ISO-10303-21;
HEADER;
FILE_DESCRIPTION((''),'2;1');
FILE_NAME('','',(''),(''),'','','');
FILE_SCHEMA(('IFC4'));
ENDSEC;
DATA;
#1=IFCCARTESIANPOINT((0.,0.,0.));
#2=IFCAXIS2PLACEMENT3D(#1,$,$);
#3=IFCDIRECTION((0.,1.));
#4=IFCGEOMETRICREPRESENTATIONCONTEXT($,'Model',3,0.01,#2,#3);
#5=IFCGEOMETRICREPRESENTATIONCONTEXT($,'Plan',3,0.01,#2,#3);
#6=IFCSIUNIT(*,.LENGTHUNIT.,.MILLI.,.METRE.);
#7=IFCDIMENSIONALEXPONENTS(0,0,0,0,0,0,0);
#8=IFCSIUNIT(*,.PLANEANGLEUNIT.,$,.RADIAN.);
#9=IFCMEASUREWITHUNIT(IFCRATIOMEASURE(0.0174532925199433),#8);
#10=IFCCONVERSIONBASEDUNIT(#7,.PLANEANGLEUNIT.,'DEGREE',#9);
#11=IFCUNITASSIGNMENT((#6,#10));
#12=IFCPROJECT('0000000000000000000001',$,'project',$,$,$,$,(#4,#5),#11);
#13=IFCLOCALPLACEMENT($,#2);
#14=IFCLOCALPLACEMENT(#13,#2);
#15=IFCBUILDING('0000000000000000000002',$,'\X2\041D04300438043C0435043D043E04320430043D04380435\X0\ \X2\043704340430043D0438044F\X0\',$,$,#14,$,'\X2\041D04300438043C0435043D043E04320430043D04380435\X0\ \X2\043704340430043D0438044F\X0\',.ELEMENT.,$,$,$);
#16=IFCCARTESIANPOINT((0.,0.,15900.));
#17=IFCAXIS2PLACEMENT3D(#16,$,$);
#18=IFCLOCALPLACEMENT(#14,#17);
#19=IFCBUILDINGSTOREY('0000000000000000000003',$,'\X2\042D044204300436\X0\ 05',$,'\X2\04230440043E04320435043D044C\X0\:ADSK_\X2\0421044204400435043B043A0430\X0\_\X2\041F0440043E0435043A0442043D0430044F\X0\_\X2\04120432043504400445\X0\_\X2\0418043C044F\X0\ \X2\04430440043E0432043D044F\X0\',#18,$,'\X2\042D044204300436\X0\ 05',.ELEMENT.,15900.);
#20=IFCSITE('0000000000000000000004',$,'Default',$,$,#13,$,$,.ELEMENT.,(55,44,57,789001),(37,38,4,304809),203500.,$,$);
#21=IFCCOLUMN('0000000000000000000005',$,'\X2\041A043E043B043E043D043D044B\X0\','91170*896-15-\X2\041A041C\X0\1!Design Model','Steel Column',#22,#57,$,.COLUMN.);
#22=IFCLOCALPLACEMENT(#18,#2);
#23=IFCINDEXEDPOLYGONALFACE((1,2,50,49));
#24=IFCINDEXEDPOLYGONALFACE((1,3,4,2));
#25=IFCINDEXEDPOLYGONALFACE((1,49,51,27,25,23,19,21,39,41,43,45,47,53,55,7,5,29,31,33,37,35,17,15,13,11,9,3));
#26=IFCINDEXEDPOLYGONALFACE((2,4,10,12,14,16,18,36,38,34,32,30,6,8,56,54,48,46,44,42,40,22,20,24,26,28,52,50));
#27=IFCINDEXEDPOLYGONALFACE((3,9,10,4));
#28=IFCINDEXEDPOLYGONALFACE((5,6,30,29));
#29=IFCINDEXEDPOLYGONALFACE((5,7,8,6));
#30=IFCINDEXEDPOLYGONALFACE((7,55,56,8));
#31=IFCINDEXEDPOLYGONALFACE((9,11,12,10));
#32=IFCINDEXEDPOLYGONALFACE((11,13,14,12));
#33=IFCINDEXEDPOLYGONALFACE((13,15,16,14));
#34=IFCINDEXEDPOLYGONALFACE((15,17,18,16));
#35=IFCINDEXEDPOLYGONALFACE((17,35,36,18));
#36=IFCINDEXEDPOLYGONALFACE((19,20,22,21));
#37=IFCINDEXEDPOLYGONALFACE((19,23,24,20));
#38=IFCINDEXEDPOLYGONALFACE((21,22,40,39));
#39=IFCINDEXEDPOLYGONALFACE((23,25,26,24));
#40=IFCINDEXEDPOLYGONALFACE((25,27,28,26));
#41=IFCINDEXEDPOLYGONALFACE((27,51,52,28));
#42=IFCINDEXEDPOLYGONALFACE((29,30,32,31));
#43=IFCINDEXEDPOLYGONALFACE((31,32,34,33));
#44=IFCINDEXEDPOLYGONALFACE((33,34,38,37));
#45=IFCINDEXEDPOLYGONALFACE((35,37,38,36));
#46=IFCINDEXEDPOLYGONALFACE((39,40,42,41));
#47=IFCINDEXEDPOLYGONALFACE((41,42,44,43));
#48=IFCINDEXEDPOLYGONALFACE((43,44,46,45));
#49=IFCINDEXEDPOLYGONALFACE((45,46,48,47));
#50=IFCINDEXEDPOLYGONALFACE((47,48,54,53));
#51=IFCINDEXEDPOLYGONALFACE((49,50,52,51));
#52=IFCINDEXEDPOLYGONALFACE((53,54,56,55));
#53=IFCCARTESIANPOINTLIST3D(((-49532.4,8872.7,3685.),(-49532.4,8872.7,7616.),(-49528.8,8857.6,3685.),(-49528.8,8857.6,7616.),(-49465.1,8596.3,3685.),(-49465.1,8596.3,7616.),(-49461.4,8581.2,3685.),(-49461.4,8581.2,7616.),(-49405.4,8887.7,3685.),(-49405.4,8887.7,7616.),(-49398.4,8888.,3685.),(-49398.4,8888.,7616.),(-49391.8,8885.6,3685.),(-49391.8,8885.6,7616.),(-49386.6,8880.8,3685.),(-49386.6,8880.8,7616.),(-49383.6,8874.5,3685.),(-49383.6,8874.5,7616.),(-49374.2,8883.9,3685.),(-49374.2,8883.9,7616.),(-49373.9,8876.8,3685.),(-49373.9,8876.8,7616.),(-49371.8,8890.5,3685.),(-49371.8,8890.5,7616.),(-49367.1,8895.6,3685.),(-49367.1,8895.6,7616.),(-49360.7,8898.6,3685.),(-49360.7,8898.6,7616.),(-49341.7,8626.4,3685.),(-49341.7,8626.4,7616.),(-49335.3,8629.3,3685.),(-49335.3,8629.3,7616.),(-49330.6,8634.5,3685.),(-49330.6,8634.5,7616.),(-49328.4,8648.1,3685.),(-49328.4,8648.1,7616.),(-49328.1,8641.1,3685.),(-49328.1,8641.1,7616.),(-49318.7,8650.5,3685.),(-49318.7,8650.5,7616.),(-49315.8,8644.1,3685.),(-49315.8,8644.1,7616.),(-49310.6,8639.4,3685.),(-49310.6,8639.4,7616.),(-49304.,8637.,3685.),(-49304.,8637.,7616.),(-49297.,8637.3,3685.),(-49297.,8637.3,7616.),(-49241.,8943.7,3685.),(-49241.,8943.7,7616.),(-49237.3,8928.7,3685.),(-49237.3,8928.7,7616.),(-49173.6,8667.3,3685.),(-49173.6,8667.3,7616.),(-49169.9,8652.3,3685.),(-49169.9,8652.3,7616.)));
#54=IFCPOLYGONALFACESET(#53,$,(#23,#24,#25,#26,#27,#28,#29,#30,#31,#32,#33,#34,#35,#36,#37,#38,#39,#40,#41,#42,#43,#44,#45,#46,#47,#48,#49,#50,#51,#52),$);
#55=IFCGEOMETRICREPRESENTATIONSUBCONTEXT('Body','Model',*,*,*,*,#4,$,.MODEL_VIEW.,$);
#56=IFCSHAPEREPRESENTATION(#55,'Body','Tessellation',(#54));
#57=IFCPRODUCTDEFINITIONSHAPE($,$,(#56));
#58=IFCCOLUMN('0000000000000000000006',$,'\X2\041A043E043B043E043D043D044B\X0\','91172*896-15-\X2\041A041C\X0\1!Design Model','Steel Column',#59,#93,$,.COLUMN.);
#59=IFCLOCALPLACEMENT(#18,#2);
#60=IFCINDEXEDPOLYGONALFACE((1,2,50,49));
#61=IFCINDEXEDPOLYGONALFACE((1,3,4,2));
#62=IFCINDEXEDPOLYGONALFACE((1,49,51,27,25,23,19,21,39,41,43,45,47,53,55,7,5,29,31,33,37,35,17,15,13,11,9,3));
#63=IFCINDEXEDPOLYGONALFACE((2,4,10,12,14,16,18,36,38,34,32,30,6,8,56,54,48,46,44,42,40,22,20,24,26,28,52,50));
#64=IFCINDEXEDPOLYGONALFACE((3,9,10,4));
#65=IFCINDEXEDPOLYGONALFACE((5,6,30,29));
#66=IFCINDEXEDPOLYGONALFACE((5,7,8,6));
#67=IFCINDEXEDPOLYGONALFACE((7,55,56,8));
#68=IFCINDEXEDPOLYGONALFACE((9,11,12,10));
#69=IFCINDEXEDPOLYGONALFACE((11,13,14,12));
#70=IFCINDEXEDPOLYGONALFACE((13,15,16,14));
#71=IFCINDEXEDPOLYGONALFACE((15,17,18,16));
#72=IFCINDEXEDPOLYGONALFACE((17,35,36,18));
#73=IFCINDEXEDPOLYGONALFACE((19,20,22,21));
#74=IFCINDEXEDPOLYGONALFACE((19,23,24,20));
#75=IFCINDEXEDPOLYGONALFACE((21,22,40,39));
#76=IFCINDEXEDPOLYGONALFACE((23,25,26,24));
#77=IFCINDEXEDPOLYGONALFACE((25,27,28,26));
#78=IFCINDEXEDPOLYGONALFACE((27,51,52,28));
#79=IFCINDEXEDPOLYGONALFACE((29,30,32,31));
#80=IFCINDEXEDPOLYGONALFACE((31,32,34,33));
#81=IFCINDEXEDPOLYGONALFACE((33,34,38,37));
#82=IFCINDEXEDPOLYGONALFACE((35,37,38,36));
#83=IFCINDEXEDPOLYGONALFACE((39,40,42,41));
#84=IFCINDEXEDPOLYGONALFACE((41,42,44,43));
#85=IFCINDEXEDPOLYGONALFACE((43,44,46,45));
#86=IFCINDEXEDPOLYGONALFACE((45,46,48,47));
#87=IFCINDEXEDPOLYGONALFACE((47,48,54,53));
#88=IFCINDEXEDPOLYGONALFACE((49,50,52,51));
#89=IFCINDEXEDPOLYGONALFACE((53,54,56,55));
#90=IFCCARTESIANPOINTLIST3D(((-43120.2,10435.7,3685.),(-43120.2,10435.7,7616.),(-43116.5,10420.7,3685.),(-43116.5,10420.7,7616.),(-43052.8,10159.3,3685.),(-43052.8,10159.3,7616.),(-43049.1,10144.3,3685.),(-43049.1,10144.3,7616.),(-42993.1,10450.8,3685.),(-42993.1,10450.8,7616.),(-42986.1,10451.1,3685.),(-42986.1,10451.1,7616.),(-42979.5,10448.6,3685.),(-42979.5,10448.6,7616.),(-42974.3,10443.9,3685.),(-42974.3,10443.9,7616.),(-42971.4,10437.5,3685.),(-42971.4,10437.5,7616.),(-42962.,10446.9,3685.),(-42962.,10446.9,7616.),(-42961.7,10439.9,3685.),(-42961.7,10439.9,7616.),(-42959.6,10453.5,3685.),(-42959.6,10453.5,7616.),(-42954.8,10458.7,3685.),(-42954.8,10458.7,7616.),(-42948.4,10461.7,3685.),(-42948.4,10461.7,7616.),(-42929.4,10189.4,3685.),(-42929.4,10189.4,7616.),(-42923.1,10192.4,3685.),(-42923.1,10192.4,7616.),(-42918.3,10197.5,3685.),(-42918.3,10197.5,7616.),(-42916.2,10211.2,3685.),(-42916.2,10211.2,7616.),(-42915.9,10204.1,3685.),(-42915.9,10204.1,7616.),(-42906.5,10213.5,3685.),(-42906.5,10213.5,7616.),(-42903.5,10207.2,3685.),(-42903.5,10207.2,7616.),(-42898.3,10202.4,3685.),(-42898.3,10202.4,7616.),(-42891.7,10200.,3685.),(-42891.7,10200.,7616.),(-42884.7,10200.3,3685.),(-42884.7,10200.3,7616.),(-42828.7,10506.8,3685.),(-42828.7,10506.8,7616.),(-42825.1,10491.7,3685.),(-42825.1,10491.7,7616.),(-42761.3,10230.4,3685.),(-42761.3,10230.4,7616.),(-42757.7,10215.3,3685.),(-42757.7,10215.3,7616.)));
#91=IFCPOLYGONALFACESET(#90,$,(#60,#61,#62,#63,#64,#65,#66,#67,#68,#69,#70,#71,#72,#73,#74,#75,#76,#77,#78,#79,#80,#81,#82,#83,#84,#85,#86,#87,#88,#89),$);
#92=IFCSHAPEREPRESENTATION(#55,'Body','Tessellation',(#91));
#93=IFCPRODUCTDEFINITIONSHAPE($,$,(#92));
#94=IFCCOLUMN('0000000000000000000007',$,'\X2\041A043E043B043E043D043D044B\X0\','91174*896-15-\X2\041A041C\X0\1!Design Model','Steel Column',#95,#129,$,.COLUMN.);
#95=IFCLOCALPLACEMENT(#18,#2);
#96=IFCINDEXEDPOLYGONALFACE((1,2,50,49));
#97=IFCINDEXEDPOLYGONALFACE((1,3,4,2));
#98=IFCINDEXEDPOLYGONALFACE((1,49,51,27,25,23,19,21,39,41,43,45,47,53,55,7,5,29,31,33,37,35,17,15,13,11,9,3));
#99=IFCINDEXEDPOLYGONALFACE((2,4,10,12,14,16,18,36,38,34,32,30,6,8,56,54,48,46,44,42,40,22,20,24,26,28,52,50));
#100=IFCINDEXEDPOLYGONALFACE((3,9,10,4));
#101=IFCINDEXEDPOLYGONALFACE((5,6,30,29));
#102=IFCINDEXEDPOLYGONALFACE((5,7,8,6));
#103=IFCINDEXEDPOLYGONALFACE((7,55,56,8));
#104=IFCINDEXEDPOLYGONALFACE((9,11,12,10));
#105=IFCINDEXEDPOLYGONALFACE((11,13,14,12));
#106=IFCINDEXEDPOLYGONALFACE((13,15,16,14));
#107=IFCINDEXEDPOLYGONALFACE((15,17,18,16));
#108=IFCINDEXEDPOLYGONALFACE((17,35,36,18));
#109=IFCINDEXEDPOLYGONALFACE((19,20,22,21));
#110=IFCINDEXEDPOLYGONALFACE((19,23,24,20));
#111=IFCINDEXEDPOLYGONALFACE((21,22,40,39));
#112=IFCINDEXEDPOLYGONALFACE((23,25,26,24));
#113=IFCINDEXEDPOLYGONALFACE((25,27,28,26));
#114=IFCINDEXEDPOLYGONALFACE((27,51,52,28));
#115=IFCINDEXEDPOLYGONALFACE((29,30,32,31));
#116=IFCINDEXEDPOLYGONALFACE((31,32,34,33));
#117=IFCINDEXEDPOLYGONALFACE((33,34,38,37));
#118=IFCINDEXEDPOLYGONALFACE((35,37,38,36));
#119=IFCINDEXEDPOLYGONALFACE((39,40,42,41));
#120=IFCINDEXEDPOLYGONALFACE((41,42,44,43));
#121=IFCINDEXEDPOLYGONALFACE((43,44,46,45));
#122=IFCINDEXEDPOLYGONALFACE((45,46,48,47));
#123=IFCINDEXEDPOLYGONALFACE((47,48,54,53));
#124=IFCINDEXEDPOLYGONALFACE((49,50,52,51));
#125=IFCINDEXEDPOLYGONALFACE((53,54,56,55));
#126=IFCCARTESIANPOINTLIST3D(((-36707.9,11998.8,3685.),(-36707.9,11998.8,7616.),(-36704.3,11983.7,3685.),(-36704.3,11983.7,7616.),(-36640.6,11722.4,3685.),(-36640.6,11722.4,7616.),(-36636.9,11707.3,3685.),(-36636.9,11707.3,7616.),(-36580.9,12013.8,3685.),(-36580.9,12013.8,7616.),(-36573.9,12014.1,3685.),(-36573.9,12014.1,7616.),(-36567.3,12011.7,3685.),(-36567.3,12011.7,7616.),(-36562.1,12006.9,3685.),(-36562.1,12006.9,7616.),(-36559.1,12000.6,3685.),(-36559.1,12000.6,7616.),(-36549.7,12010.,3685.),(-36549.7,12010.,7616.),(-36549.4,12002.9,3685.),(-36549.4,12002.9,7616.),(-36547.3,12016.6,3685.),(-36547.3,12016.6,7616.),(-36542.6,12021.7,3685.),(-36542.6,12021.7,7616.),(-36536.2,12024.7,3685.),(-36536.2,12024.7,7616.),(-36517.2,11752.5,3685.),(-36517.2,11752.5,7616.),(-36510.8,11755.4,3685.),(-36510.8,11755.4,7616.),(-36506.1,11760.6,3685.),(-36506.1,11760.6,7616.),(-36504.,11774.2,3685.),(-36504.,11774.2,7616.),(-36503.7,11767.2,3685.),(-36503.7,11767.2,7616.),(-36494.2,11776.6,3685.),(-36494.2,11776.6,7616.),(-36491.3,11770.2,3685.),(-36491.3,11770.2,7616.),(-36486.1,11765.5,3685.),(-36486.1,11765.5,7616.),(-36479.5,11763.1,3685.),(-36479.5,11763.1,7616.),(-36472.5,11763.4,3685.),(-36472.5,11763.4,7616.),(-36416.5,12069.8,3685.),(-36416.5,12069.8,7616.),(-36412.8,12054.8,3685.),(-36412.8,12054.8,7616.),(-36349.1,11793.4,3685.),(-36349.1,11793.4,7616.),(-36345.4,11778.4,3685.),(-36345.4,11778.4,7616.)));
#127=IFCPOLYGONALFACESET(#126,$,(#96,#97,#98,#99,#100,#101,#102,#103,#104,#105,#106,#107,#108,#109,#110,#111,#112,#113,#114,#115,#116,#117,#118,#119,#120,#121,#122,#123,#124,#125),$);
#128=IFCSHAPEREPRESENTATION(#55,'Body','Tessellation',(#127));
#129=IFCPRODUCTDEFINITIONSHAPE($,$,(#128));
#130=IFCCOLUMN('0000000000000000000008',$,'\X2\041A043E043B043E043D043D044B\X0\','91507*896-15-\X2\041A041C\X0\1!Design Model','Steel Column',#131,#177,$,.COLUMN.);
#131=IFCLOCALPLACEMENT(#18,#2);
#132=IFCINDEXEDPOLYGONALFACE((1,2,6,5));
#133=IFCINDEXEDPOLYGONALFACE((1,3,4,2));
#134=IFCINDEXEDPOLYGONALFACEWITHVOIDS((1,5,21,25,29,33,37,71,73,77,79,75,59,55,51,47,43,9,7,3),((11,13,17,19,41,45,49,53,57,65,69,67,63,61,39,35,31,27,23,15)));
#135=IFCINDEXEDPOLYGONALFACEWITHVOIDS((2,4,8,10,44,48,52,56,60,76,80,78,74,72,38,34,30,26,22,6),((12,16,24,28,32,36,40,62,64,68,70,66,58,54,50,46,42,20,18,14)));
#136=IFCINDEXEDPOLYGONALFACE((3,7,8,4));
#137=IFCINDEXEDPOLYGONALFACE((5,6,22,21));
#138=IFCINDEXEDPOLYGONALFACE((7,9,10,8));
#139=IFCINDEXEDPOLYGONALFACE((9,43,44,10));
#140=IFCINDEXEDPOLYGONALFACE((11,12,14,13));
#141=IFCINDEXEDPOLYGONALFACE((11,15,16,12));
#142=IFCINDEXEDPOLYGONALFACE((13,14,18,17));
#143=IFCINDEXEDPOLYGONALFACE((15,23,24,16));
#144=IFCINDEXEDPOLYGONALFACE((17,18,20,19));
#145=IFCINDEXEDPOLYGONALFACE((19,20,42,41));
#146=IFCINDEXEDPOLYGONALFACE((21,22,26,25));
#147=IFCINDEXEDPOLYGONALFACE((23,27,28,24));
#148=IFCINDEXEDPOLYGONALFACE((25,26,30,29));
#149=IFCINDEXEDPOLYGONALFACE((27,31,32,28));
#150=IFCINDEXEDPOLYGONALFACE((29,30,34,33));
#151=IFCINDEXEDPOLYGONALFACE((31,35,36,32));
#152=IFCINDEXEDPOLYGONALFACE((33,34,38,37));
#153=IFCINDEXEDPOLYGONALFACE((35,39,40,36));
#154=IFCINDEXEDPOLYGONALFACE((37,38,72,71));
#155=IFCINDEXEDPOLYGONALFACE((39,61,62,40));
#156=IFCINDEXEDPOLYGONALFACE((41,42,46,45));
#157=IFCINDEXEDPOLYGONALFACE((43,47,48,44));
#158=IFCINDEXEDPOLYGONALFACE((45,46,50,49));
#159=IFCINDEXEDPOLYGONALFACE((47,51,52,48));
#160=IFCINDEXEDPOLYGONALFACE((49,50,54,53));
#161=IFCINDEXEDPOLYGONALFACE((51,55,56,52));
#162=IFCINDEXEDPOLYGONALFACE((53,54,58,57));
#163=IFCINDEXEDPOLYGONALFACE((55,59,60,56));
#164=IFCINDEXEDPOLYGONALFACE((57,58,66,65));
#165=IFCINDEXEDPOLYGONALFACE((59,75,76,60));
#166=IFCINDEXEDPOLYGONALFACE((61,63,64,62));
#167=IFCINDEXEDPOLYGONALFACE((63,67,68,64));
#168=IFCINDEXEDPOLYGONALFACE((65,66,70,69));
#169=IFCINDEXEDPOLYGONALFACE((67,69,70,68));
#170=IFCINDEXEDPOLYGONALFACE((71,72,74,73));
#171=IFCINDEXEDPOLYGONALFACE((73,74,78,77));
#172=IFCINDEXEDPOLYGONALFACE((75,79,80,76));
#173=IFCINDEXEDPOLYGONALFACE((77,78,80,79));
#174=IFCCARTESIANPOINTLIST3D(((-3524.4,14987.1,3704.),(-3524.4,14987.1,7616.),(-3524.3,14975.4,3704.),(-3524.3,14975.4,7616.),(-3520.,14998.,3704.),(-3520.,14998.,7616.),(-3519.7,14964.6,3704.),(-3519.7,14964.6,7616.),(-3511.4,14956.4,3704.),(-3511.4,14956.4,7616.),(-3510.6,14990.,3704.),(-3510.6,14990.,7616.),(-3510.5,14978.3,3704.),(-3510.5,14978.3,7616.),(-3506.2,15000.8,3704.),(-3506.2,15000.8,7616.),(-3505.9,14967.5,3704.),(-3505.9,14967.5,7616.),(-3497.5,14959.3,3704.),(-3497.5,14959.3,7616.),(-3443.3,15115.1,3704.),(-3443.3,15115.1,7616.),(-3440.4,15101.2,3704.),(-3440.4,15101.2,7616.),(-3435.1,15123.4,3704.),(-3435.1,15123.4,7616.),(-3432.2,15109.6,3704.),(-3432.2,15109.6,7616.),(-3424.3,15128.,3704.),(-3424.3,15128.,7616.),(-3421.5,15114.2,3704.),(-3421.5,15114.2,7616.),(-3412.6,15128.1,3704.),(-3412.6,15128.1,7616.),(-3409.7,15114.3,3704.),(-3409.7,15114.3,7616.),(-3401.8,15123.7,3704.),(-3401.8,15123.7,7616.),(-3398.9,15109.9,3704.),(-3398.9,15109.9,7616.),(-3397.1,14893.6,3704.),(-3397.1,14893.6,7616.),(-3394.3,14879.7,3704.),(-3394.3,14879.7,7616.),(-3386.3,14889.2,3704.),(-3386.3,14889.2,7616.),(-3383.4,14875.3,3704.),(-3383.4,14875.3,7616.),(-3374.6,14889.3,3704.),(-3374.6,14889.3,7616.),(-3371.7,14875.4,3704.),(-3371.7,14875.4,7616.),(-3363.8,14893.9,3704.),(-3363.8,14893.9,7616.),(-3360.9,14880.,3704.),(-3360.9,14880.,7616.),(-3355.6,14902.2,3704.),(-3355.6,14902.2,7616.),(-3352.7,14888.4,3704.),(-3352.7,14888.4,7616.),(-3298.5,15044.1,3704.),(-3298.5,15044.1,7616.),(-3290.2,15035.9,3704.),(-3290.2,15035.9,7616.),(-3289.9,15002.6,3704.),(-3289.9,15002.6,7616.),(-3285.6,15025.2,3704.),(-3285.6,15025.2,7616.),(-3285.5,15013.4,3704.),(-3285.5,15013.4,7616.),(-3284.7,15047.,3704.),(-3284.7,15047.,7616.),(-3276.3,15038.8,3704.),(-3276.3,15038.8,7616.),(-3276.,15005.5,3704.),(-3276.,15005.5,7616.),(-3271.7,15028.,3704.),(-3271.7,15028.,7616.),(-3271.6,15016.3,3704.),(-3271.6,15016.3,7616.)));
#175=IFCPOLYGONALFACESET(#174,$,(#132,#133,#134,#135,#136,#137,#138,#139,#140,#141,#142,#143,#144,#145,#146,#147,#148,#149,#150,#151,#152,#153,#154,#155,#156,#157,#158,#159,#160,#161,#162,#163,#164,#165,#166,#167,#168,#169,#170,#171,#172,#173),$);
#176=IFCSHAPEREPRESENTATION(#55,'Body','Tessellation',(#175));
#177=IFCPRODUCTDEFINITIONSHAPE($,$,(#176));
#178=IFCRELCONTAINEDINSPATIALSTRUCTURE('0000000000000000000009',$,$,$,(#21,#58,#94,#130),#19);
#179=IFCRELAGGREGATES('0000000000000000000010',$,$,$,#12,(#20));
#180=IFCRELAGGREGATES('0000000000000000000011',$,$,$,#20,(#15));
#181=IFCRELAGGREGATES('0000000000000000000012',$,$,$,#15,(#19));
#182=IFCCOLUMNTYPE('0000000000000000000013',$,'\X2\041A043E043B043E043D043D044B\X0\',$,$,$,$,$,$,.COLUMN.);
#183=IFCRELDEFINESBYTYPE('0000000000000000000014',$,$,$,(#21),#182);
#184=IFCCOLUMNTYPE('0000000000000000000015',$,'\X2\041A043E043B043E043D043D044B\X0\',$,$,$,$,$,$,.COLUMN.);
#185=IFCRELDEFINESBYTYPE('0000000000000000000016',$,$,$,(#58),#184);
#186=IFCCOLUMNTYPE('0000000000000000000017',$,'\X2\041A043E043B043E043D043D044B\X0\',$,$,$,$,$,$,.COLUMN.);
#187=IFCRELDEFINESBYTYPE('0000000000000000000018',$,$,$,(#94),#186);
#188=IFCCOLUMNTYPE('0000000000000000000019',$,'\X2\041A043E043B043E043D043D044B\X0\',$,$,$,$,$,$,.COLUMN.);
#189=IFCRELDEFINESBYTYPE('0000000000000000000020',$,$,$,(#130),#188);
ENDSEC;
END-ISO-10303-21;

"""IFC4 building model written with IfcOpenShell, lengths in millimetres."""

from ifc_helpers import new_model, entity, si_unit, converted_unit, direction, frame, origin, place, context, subcontext, project, spatial, indexed_curve, outline, extrude, type_object, element, save


model = new_model("IFC4")

# Units and contexts
model_context = context("Model", 3, precision=0.01, world=origin(), true_north=direction((0.0, 1.0)))
plan_context = context("Plan", 3, precision=0.01, world=origin(), true_north=direction((0.0, 1.0)))
body_context = subcontext(model_context, "Body", "Model", "MODEL_VIEW")
ifc_project = project(units=[si_unit("LENGTHUNIT", "METRE", prefix="MILLI"), converted_unit("PLANEANGLEUNIT", "DEGREE", entity("IfcRatioMeasure", 0.0174532925199433), si_unit("PLANEANGLEUNIT", "RADIAN"), dimensions=[0, 0, 0, 0, 0, 0, 0])], contexts=[model_context, plan_context])

# Site, building, storey
site_placement = place(None, origin())
site = spatial("IfcSite", under=ifc_project, at=site_placement, Name="Default", CompositionType="ELEMENT", RefLatitude=(55, 44, 57, 789001), RefLongitude=(37, 38, 4, 304809), RefElevation=203500.0)
building_placement = place(site_placement, origin())
building = spatial("IfcBuilding", under=site, at=building_placement, Name="Наименование здания", LongName="Наименование здания", CompositionType="ELEMENT")
storey_placement = place(building_placement, frame((0.0, 0.0, 15900.0)))
storey = spatial("IfcBuildingStorey", under=building, at=storey_placement, Name="Этаж 05", ObjectType="Уровень:ADSK_Стрелка_Проектная_Вверх_Имя уровня", LongName="Этаж 05", CompositionType="ELEMENT", Elevation=15900.0)

# Columns
placement = place(storey_placement, origin())
column_type_1 = type_object("IfcColumnType", Name="Колонны", PredefinedType="COLUMN")
element("IfcColumn", 1, at=placement, inside=storey, type_object=column_type_1, Name="Колонны", Description="91170*896-15-КМ1!Design Model", ObjectType="Steel Column", PredefinedType="COLUMN", context=body_context, shape_type="SweptSolid", body=[
    extrude(outline(indexed_curve([(-150.0, -150.0), (-134.5, -150.0), (-134.5, -23.0), (-133.1, -16.1), (-129.2, -10.3), (-123.4, -6.4), (-116.5, -5.0), (116.5, -5.0), (123.4, -6.4), (129.2, -10.3), (133.1, -16.1), (134.5, -23.0), (134.5, -150.0), (150.0, -150.0), (150.0, 150.0), (134.5, 150.0), (134.5, 23.0), (133.1, 16.1), (129.2, 10.3), (123.4, 6.4), (116.5, 5.0), (-116.5, 5.0), (-123.4, 6.4), (-129.2, 10.3), (-133.1, 16.1), (-134.5, 23.0), (-134.5, 150.0), (-150.0, 150.0), (-150.0, -150.0)], self_intersect=False)), frame((-49351.2, 8762.5, 3685.0), z_axis=(0.0, 0.0, 1.0), x_axis=(-0.236826, 0.971552, 0.0)), (0.0, 0.0, 1.0), 3931.0),
])
column_type_2 = type_object("IfcColumnType", Name="Колонны", PredefinedType="COLUMN")
element("IfcColumn", 2, at=placement, inside=storey, type_object=column_type_2, Name="Колонны", Description="91172*896-15-КМ1!Design Model", ObjectType="Steel Column", PredefinedType="COLUMN", context=body_context, shape_type="SweptSolid", body=[
    extrude(outline(indexed_curve([(-150.0, -150.0), (-134.5, -150.0), (-134.5, -23.0), (-133.1, -16.1), (-129.2, -10.3), (-123.4, -6.4), (-116.5, -5.0), (116.5, -5.0), (123.4, -6.4), (129.2, -10.3), (133.1, -16.1), (134.5, -23.0), (134.5, -150.0), (150.0, -150.0), (150.0, 150.0), (134.5, 150.0), (134.5, 23.0), (133.1, 16.1), (129.2, 10.3), (123.4, 6.4), (116.5, 5.0), (-116.5, 5.0), (-123.4, 6.4), (-129.2, 10.3), (-133.1, 16.1), (-134.5, 23.0), (-134.5, 150.0), (-150.0, 150.0), (-150.0, -150.0)], self_intersect=False)), frame((-42938.9, 10325.5, 3685.0), z_axis=(0.0, 0.0, 1.0), x_axis=(-0.236826, 0.971552, 0.0)), (0.0, 0.0, 1.0), 3931.0),
])
column_type_3 = type_object("IfcColumnType", Name="Колонны", PredefinedType="COLUMN")
element("IfcColumn", 3, at=placement, inside=storey, type_object=column_type_3, Name="Колонны", Description="91174*896-15-КМ1!Design Model", ObjectType="Steel Column", PredefinedType="COLUMN", context=body_context, shape_type="SweptSolid", body=[
    extrude(outline(indexed_curve([(-150.0, -150.0), (-134.5, -150.0), (-134.5, -23.0), (-133.1, -16.1), (-129.2, -10.3), (-123.4, -6.4), (-116.5, -5.0), (116.5, -5.0), (123.4, -6.4), (129.2, -10.3), (133.1, -16.1), (134.5, -23.0), (134.5, -150.0), (150.0, -150.0), (150.0, 150.0), (134.5, 150.0), (134.5, 23.0), (133.1, 16.1), (129.2, 10.3), (123.4, 6.4), (116.5, 5.0), (-116.5, 5.0), (-123.4, 6.4), (-129.2, 10.3), (-133.1, 16.1), (-134.5, 23.0), (-134.5, 150.0), (-150.0, 150.0), (-150.0, -150.0)], self_intersect=False)), frame((-36526.7, 11888.6, 3685.0), z_axis=(0.0, 0.0, 1.0), x_axis=(-0.236826, 0.971552, 0.0)), (0.0, 0.0, 1.0), 3931.0),
])
column_type_4 = type_object("IfcColumnType", Name="Колонны", PredefinedType="COLUMN")
element("IfcColumn", 4, at=placement, inside=storey, type_object=column_type_4, Name="Колонны", Description="91507*896-15-КМ1!Design Model", ObjectType="Steel Column", PredefinedType="COLUMN", context=body_context, shape_type="SweptSolid", body=[
    extrude(outline(indexed_curve([(49.1, -111.7), (60.9, -111.7), (71.7, -107.3), (79.9, -99.0), (84.4, -88.2), (111.7, 49.1), (111.7, 60.9), (107.3, 71.7), (99.0, 79.9), (88.2, 84.4), (-49.1, 111.7), (-60.9, 111.7), (-71.7, 107.3), (-79.9, 99.0), (-84.4, 88.2), (-111.7, -49.1), (-111.7, -60.9), (-107.3, -71.7), (-99.0, -79.9), (-88.2, -84.4), (49.1, -111.7)], self_intersect=False), holes=[indexed_curve([(-76.4, -76.6), (-87.2, -72.1), (-95.5, -63.8), (-100.0, -53.0), (-100.0, -41.3), (-76.6, 76.4), (-72.1, 87.2), (-63.8, 95.5), (-53.0, 100.0), (-41.3, 100.0), (76.4, 76.6), (87.2, 72.1), (95.5, 63.8), (100.0, 53.0), (100.0, 41.3), (76.6, -76.4), (72.1, -87.2), (63.8, -95.5), (53.0, -100.0), (41.3, -100.0), (-76.4, -76.6)], self_intersect=False)]), frame((-3398.0, 15001.7, 3704.1), z_axis=(0.0, 0.0, 1.0), x_axis=(0.927337, -0.374228, 0.0)), (0.0, 0.0, 1.0), 3911.9),
])

save(model, "model.ifc")
